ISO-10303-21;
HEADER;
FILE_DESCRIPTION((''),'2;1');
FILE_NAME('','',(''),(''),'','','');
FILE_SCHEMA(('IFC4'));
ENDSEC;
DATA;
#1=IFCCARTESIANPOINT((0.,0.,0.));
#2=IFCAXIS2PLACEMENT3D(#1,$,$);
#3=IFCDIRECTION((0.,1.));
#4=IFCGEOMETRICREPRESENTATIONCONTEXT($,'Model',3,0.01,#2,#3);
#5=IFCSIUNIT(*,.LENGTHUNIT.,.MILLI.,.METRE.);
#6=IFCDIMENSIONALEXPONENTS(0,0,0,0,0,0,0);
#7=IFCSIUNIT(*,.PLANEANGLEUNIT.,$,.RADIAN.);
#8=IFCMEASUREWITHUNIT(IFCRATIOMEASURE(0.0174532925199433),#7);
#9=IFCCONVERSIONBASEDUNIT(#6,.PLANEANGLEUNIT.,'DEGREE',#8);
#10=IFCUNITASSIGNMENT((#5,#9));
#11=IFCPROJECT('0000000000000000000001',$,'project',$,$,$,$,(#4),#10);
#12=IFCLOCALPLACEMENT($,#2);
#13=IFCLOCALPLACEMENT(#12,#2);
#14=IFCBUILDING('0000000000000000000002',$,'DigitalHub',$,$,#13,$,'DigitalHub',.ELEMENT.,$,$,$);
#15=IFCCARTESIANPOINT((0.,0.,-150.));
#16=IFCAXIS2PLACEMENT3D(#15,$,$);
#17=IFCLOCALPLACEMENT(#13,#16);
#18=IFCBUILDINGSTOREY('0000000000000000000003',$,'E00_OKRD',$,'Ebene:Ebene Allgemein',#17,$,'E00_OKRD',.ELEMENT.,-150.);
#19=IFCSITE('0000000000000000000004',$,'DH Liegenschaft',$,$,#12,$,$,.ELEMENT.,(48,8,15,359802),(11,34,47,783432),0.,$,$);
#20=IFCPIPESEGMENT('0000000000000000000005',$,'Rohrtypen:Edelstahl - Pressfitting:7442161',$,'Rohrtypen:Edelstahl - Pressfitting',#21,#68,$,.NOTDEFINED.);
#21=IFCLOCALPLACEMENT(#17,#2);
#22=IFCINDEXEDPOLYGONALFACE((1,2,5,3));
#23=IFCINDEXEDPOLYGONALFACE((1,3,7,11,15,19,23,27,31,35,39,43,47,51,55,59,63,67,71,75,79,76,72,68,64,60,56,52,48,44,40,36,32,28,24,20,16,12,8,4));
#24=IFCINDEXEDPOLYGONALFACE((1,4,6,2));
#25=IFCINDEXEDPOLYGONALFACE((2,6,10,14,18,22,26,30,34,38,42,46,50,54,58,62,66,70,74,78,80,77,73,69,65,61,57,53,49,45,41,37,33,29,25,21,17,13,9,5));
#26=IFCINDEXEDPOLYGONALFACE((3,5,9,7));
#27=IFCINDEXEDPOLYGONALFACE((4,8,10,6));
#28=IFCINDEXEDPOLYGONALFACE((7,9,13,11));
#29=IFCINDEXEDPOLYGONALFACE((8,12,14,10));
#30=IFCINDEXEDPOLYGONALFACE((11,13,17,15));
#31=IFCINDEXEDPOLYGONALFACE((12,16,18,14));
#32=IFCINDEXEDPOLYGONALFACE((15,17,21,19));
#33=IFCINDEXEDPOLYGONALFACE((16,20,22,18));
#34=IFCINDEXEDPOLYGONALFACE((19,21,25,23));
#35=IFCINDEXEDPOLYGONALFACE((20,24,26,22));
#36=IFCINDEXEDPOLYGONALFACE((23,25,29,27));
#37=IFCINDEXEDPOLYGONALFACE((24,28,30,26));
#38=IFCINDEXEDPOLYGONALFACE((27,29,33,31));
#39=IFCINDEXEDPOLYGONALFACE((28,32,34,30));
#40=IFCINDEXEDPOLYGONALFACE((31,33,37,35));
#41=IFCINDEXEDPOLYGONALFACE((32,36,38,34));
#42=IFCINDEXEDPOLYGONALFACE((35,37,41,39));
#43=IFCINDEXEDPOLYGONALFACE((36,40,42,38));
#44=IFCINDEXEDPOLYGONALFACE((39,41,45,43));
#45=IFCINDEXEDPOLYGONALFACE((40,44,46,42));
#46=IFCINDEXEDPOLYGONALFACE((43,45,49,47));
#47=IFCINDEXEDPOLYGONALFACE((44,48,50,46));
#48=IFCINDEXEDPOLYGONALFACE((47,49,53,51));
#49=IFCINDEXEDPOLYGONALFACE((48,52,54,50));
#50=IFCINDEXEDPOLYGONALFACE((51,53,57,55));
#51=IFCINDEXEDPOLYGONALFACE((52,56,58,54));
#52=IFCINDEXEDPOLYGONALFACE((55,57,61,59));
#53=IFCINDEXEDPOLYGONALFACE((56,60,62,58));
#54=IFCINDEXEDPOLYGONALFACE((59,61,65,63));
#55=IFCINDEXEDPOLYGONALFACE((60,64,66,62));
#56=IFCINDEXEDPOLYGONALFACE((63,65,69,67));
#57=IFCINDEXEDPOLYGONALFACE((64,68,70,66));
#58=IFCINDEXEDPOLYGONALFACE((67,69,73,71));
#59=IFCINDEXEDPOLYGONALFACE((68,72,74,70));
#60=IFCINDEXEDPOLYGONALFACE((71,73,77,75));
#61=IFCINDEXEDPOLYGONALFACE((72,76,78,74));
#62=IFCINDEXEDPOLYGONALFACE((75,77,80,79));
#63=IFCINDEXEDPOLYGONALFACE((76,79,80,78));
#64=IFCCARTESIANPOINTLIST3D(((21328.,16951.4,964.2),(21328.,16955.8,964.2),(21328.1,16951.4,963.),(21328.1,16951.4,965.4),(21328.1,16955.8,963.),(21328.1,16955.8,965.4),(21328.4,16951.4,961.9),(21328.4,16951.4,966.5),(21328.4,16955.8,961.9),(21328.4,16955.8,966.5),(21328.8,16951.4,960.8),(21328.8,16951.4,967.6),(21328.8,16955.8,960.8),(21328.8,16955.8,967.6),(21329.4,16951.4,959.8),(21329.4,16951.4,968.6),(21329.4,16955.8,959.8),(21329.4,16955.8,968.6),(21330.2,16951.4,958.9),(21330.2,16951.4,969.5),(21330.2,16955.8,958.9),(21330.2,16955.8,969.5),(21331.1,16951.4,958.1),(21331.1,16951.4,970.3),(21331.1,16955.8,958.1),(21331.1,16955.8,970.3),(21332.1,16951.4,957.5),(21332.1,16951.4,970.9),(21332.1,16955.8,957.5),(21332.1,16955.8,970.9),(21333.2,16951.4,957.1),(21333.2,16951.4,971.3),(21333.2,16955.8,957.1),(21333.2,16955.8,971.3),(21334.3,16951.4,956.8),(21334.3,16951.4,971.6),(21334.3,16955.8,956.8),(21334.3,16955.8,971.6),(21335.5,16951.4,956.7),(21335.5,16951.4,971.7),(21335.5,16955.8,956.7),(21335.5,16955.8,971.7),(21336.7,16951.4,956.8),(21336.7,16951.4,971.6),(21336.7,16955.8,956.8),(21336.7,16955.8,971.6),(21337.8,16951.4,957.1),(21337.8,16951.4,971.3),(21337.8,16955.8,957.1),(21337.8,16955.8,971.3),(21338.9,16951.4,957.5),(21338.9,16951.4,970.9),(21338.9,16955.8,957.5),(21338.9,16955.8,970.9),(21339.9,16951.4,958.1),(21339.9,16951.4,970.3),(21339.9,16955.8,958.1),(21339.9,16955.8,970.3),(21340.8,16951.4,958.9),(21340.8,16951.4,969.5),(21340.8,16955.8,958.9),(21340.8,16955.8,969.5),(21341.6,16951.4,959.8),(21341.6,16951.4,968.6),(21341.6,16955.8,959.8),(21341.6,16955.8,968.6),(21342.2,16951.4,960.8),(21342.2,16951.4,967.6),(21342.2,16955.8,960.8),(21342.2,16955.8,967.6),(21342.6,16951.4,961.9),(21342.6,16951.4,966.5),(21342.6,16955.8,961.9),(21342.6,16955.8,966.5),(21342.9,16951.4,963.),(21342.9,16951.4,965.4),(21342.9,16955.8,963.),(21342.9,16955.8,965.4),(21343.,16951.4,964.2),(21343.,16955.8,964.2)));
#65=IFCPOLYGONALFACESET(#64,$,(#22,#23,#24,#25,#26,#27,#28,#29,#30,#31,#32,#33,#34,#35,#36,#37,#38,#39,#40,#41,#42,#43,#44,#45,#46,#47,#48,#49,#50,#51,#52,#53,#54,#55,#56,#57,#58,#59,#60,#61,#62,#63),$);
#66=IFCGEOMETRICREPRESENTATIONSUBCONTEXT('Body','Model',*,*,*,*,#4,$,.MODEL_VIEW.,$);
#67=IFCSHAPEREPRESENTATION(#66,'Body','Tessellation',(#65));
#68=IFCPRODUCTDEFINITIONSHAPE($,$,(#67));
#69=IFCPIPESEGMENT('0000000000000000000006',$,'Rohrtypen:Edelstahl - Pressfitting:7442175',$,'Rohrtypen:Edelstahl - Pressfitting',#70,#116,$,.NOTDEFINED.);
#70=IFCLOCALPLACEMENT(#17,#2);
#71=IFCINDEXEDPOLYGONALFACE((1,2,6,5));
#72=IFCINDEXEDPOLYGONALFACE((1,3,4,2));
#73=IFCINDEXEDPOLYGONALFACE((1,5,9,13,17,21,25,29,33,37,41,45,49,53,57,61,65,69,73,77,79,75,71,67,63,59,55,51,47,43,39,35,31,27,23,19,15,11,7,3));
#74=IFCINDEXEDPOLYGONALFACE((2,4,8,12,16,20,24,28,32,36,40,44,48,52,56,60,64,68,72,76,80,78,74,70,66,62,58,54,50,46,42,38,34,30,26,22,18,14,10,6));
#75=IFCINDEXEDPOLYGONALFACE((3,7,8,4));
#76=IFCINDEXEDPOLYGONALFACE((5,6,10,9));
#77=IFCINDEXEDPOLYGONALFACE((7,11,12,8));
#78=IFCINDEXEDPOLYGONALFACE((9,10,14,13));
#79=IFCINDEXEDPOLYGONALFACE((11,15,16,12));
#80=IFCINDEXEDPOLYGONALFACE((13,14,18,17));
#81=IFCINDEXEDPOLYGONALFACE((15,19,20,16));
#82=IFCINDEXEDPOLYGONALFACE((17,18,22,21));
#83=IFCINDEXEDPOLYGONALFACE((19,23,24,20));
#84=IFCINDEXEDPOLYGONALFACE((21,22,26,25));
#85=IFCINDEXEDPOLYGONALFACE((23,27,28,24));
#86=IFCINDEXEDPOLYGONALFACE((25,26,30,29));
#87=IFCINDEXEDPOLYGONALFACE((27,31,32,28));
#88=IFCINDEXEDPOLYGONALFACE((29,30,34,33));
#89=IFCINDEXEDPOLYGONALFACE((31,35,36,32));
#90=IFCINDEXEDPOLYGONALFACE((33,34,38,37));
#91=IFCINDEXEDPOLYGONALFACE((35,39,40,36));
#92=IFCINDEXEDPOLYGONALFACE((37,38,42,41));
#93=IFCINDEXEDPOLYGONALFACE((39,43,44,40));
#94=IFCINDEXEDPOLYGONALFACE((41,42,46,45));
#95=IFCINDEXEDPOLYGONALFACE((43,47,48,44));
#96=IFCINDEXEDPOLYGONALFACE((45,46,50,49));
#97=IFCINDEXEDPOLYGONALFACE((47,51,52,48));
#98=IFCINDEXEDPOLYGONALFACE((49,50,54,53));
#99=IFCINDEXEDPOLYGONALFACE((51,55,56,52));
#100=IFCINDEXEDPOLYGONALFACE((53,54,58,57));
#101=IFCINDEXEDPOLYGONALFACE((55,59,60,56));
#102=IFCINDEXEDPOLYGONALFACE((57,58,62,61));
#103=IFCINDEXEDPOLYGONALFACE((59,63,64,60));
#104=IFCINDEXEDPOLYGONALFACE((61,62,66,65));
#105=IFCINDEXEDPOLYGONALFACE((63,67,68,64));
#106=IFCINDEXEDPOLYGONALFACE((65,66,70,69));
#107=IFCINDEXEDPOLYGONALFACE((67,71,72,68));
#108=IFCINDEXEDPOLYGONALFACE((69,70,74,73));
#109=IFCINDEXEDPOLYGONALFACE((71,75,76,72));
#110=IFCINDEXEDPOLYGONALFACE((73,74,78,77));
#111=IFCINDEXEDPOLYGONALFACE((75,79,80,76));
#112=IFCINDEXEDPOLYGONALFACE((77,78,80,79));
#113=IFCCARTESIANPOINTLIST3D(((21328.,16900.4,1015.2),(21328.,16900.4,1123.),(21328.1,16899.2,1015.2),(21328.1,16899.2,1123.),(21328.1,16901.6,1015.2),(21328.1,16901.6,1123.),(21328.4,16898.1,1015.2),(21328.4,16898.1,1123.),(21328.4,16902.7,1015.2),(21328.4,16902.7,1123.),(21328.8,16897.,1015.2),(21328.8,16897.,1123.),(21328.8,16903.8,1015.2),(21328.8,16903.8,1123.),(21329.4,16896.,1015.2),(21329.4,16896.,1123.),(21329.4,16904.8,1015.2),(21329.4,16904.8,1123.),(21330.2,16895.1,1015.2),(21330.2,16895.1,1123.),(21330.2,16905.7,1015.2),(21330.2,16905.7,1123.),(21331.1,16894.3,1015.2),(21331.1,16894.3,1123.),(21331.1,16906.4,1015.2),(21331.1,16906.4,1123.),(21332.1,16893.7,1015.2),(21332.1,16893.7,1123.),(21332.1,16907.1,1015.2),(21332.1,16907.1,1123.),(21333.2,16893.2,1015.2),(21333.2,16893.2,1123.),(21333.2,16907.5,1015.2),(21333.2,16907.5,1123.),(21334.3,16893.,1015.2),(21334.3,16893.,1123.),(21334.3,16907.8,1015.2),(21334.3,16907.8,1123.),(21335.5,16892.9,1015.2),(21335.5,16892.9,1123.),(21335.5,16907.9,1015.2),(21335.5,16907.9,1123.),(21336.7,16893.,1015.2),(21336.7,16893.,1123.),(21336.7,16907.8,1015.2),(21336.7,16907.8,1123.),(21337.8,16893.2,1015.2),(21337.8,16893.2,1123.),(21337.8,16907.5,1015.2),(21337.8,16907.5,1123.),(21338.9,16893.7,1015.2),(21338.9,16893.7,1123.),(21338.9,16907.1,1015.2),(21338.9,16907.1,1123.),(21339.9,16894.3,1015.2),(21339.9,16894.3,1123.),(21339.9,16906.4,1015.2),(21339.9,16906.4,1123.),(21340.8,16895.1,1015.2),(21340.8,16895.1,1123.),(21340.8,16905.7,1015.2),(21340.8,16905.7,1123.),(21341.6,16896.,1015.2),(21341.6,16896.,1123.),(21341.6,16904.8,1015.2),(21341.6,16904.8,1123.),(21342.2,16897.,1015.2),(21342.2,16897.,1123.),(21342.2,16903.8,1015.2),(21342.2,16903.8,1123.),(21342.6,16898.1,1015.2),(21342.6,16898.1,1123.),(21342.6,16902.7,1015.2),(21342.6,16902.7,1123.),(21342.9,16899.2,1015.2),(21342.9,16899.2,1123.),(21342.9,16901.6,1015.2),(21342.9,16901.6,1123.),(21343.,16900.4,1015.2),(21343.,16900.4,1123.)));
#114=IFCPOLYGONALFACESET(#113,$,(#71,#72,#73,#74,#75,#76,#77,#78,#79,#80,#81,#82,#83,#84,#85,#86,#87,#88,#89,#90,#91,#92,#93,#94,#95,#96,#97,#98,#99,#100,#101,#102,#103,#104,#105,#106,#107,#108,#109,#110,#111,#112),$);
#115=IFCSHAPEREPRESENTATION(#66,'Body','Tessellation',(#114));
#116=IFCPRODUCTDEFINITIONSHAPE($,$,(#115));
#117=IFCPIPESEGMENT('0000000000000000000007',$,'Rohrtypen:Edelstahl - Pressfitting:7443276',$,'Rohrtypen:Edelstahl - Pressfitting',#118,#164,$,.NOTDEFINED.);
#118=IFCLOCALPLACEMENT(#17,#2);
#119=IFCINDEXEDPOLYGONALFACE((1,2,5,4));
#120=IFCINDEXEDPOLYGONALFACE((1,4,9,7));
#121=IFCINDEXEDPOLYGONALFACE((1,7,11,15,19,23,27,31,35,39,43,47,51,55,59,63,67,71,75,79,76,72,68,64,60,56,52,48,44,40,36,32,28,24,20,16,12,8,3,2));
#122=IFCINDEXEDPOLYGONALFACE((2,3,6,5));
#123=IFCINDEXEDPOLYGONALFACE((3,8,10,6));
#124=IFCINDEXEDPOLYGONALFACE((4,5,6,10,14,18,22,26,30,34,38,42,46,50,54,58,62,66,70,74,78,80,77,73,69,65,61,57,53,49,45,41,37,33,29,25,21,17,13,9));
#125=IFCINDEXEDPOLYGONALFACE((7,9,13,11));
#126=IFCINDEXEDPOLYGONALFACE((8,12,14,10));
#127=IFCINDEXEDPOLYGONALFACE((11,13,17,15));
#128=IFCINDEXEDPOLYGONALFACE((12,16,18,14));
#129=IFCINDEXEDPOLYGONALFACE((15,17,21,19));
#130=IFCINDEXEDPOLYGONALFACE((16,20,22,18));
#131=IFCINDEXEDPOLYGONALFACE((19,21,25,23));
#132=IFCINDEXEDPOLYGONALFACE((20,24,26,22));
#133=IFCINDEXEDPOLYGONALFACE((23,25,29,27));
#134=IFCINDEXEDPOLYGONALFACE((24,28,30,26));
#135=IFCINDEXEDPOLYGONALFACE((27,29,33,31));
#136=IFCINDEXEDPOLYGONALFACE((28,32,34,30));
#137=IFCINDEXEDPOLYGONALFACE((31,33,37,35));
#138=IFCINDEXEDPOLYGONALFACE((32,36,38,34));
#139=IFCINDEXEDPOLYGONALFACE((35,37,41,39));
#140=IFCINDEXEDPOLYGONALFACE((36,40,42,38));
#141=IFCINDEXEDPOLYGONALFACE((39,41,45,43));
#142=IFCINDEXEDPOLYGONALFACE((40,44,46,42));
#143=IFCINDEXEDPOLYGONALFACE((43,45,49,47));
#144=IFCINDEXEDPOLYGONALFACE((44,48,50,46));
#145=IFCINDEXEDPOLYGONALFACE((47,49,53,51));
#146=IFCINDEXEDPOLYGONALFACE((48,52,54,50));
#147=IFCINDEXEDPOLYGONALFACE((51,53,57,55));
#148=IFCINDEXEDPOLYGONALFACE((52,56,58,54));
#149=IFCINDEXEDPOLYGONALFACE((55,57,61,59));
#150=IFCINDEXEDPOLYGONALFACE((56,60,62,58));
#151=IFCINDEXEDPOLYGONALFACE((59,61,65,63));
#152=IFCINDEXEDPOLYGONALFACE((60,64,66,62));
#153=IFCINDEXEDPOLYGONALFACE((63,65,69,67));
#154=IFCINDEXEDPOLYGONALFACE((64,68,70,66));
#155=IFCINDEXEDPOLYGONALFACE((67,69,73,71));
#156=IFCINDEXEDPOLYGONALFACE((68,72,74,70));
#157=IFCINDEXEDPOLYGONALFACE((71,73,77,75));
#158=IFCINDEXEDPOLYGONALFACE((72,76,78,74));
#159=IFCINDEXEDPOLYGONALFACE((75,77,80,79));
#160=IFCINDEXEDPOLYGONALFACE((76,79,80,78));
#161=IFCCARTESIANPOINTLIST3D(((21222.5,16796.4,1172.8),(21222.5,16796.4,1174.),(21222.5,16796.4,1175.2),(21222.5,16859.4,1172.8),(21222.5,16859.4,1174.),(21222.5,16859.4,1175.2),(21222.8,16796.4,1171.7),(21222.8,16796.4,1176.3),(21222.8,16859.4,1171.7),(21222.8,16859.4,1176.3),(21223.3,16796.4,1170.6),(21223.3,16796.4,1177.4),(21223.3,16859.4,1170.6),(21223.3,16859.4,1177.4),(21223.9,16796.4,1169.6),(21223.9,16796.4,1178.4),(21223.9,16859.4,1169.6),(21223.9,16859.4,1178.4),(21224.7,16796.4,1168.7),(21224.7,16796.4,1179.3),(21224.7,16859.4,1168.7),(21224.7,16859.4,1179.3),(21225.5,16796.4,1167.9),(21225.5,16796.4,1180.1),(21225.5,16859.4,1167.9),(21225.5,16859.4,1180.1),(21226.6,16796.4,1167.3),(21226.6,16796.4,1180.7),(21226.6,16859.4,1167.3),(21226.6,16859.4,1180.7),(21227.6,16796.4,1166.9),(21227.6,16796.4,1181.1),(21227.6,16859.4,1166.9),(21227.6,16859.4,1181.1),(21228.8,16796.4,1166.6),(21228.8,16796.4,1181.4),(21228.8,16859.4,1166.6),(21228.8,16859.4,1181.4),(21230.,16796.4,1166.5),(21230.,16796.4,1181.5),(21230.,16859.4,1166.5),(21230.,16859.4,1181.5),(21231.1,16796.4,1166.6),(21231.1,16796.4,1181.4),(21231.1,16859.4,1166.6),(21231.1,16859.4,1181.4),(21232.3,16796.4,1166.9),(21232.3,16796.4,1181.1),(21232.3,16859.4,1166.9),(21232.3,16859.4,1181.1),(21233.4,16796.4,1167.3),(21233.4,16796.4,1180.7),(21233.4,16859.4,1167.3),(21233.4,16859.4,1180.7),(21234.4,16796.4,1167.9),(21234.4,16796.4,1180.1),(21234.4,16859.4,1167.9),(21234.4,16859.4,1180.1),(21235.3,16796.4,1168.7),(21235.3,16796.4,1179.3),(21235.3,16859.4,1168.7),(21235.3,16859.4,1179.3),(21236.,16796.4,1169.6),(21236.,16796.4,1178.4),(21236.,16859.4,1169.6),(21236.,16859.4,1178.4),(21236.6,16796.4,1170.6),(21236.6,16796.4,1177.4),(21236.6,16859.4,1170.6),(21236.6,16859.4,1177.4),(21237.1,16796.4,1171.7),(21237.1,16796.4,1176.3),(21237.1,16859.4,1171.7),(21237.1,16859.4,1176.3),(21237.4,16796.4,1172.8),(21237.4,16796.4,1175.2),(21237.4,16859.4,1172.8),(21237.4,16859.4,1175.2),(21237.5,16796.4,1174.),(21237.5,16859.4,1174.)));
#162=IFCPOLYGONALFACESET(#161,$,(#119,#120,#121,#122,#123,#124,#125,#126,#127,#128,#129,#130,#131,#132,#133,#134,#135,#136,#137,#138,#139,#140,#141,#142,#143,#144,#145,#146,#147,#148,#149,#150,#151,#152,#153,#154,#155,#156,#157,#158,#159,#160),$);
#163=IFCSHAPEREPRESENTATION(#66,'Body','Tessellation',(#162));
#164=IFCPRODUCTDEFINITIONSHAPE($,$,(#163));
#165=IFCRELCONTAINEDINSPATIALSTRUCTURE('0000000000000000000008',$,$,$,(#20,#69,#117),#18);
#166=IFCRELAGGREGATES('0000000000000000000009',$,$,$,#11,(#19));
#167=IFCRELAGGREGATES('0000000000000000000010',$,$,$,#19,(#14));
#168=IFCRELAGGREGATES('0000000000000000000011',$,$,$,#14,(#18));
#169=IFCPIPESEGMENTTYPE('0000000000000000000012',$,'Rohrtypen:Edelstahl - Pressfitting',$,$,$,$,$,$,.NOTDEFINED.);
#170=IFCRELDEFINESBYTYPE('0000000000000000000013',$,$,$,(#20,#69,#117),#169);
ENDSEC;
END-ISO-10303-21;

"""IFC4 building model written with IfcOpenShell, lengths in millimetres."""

from ifc_helpers import new_model, entity, si_unit, converted_unit, direction, frame, origin, place, context, subcontext, project, spatial, indexed_curve, outline, extrude, type_object, element, save


model = new_model("IFC4")

# Units and contexts
model_context = context("Model", 3, precision=0.01, world=origin(), true_north=direction((0.0, 1.0)))
body_context = subcontext(model_context, "Body", "Model", "MODEL_VIEW")
ifc_project = project(units=[si_unit("LENGTHUNIT", "METRE", prefix="MILLI"), converted_unit("PLANEANGLEUNIT", "DEGREE", entity("IfcRatioMeasure", 0.0174532925199433), si_unit("PLANEANGLEUNIT", "RADIAN"), dimensions=[0, 0, 0, 0, 0, 0, 0])], contexts=[model_context])

# Site, building, storey
site_placement = place(None, origin())
site = spatial("IfcSite", under=ifc_project, at=site_placement, Name="DH Liegenschaft", CompositionType="ELEMENT", RefLatitude=(48, 8, 15, 359802), RefLongitude=(11, 34, 47, 783432), RefElevation=0.0)
building_placement = place(site_placement, origin())
building = spatial("IfcBuilding", under=site, at=building_placement, Name="DigitalHub", LongName="DigitalHub", CompositionType="ELEMENT")
storey_placement = place(building_placement, frame((0.0, 0.0, -150.0)))
storey = spatial("IfcBuildingStorey", under=building, at=storey_placement, Name="E00_OKRD", ObjectType="Ebene:Ebene Allgemein", LongName="E00_OKRD", CompositionType="ELEMENT", Elevation=-150.0)

# Pipe segments
pipe_segment_type_1 = type_object("IfcPipeSegmentType", Name="Rohrtypen:Edelstahl - Pressfitting", PredefinedType="NOTDEFINED")
pipe_segment_1_placement = place(storey_placement, frame((21326.4, 16951.4, 955.1)))
element("IfcPipeSegment", 1, at=pipe_segment_1_placement, inside=storey, type_object=pipe_segment_type_1, Name="Rohrtypen:Edelstahl - Pressfitting:7442161", ObjectType="Rohrtypen:Edelstahl - Pressfitting", PredefinedType="NOTDEFINED", context=body_context, shape_type="SweptSolid", body=[
    extrude(outline(indexed_curve([(7.5, 0.0), (7.4, 1.2), (7.1, 2.3), (6.7, 3.4), (6.1, 4.4), (5.3, 5.3), (4.4, 6.1), (3.4, 6.7), (2.3, 7.1), (1.2, 7.4), (0.0, 7.5), (-1.2, 7.4), (-2.3, 7.1), (-3.4, 6.7), (-4.4, 6.1), (-5.3, 5.3), (-6.1, 4.4), (-6.7, 3.4), (-7.1, 2.3), (-7.4, 1.2), (-7.5, 0.0), (-7.4, -1.2), (-7.1, -2.3), (-6.7, -3.4), (-6.1, -4.4), (-5.3, -5.3), (-4.4, -6.1), (-3.4, -6.7), (-2.3, -7.1), (-1.2, -7.4), (0.0, -7.5), (1.2, -7.4), (2.3, -7.1), (3.4, -6.7), (4.4, -6.1), (5.3, -5.3), (6.1, -4.4), (6.7, -3.4), (7.1, -2.3), (7.4, -1.2), (7.5, 0.0)], self_intersect=False)), frame((9.1, 0.0, 9.1), z_axis=(0.0, 1.0, 0.0), x_axis=(-1.0, 0.0, 0.0)), (0.0, 0.0, 1.0), 4.4),
])
pipe_segment_2_placement = place(storey_placement, frame((21326.4, 16891.3, 1015.2)))
element("IfcPipeSegment", 2, at=pipe_segment_2_placement, inside=storey, type_object=pipe_segment_type_1, Name="Rohrtypen:Edelstahl - Pressfitting:7442175", ObjectType="Rohrtypen:Edelstahl - Pressfitting", PredefinedType="NOTDEFINED", context=body_context, shape_type="SweptSolid", body=[
    extrude(outline(indexed_curve([(7.5, 0.0), (7.4, 1.2), (7.1, 2.3), (6.7, 3.4), (6.1, 4.4), (5.3, 5.3), (4.4, 6.1), (3.4, 6.7), (2.3, 7.1), (1.2, 7.4), (0.0, 7.5), (-1.2, 7.4), (-2.3, 7.1), (-3.4, 6.7), (-4.4, 6.1), (-5.3, 5.3), (-6.1, 4.4), (-6.7, 3.4), (-7.1, 2.3), (-7.4, 1.2), (-7.5, 0.0), (-7.4, -1.2), (-7.1, -2.3), (-6.7, -3.4), (-6.1, -4.4), (-5.3, -5.3), (-4.4, -6.1), (-3.4, -6.7), (-2.3, -7.1), (-1.2, -7.4), (0.0, -7.5), (1.2, -7.4), (2.3, -7.1), (3.4, -6.7), (4.4, -6.1), (5.3, -5.3), (6.1, -4.4), (6.7, -3.4), (7.1, -2.3), (7.4, -1.2), (7.5, 0.0)], self_intersect=False)), frame((9.1, 9.1, 0.0), z_axis=(0.0, 0.0, 1.0), x_axis=(-1.0, 0.0, 0.0)), (0.0, 0.0, 1.0), 107.8),
])
pipe_segment_3_placement = place(storey_placement, frame((21220.9, 16796.4, 1164.9)))
element("IfcPipeSegment", 3, at=pipe_segment_3_placement, inside=storey, type_object=pipe_segment_type_1, Name="Rohrtypen:Edelstahl - Pressfitting:7443276", ObjectType="Rohrtypen:Edelstahl - Pressfitting", PredefinedType="NOTDEFINED", context=body_context, shape_type="SweptSolid", body=[
    extrude(outline(indexed_curve([(7.5, 0.0), (7.4, 1.2), (7.1, 2.3), (6.7, 3.4), (6.1, 4.4), (5.3, 5.3), (4.4, 6.1), (3.4, 6.7), (2.3, 7.1), (1.2, 7.4), (0.0, 7.5), (-1.2, 7.4), (-2.3, 7.1), (-3.4, 6.7), (-4.4, 6.1), (-5.3, 5.3), (-6.1, 4.4), (-6.7, 3.4), (-7.1, 2.3), (-7.4, 1.2), (-7.5, 0.0), (-7.4, -1.2), (-7.1, -2.3), (-6.7, -3.4), (-6.1, -4.4), (-5.3, -5.3), (-4.4, -6.1), (-3.4, -6.7), (-2.3, -7.1), (-1.2, -7.4), (0.0, -7.5), (1.2, -7.4), (2.3, -7.1), (3.4, -6.7), (4.4, -6.1), (5.3, -5.3), (6.1, -4.4), (6.7, -3.4), (7.1, -2.3), (7.4, -1.2), (7.5, 0.0)], self_intersect=False)), frame((9.1, 0.0, 9.1), z_axis=(0.0, 1.0, 0.0), x_axis=(-1.0, 0.0, 0.0)), (0.0, 0.0, 1.0), 63.0),
])

save(model, "model.ifc")
